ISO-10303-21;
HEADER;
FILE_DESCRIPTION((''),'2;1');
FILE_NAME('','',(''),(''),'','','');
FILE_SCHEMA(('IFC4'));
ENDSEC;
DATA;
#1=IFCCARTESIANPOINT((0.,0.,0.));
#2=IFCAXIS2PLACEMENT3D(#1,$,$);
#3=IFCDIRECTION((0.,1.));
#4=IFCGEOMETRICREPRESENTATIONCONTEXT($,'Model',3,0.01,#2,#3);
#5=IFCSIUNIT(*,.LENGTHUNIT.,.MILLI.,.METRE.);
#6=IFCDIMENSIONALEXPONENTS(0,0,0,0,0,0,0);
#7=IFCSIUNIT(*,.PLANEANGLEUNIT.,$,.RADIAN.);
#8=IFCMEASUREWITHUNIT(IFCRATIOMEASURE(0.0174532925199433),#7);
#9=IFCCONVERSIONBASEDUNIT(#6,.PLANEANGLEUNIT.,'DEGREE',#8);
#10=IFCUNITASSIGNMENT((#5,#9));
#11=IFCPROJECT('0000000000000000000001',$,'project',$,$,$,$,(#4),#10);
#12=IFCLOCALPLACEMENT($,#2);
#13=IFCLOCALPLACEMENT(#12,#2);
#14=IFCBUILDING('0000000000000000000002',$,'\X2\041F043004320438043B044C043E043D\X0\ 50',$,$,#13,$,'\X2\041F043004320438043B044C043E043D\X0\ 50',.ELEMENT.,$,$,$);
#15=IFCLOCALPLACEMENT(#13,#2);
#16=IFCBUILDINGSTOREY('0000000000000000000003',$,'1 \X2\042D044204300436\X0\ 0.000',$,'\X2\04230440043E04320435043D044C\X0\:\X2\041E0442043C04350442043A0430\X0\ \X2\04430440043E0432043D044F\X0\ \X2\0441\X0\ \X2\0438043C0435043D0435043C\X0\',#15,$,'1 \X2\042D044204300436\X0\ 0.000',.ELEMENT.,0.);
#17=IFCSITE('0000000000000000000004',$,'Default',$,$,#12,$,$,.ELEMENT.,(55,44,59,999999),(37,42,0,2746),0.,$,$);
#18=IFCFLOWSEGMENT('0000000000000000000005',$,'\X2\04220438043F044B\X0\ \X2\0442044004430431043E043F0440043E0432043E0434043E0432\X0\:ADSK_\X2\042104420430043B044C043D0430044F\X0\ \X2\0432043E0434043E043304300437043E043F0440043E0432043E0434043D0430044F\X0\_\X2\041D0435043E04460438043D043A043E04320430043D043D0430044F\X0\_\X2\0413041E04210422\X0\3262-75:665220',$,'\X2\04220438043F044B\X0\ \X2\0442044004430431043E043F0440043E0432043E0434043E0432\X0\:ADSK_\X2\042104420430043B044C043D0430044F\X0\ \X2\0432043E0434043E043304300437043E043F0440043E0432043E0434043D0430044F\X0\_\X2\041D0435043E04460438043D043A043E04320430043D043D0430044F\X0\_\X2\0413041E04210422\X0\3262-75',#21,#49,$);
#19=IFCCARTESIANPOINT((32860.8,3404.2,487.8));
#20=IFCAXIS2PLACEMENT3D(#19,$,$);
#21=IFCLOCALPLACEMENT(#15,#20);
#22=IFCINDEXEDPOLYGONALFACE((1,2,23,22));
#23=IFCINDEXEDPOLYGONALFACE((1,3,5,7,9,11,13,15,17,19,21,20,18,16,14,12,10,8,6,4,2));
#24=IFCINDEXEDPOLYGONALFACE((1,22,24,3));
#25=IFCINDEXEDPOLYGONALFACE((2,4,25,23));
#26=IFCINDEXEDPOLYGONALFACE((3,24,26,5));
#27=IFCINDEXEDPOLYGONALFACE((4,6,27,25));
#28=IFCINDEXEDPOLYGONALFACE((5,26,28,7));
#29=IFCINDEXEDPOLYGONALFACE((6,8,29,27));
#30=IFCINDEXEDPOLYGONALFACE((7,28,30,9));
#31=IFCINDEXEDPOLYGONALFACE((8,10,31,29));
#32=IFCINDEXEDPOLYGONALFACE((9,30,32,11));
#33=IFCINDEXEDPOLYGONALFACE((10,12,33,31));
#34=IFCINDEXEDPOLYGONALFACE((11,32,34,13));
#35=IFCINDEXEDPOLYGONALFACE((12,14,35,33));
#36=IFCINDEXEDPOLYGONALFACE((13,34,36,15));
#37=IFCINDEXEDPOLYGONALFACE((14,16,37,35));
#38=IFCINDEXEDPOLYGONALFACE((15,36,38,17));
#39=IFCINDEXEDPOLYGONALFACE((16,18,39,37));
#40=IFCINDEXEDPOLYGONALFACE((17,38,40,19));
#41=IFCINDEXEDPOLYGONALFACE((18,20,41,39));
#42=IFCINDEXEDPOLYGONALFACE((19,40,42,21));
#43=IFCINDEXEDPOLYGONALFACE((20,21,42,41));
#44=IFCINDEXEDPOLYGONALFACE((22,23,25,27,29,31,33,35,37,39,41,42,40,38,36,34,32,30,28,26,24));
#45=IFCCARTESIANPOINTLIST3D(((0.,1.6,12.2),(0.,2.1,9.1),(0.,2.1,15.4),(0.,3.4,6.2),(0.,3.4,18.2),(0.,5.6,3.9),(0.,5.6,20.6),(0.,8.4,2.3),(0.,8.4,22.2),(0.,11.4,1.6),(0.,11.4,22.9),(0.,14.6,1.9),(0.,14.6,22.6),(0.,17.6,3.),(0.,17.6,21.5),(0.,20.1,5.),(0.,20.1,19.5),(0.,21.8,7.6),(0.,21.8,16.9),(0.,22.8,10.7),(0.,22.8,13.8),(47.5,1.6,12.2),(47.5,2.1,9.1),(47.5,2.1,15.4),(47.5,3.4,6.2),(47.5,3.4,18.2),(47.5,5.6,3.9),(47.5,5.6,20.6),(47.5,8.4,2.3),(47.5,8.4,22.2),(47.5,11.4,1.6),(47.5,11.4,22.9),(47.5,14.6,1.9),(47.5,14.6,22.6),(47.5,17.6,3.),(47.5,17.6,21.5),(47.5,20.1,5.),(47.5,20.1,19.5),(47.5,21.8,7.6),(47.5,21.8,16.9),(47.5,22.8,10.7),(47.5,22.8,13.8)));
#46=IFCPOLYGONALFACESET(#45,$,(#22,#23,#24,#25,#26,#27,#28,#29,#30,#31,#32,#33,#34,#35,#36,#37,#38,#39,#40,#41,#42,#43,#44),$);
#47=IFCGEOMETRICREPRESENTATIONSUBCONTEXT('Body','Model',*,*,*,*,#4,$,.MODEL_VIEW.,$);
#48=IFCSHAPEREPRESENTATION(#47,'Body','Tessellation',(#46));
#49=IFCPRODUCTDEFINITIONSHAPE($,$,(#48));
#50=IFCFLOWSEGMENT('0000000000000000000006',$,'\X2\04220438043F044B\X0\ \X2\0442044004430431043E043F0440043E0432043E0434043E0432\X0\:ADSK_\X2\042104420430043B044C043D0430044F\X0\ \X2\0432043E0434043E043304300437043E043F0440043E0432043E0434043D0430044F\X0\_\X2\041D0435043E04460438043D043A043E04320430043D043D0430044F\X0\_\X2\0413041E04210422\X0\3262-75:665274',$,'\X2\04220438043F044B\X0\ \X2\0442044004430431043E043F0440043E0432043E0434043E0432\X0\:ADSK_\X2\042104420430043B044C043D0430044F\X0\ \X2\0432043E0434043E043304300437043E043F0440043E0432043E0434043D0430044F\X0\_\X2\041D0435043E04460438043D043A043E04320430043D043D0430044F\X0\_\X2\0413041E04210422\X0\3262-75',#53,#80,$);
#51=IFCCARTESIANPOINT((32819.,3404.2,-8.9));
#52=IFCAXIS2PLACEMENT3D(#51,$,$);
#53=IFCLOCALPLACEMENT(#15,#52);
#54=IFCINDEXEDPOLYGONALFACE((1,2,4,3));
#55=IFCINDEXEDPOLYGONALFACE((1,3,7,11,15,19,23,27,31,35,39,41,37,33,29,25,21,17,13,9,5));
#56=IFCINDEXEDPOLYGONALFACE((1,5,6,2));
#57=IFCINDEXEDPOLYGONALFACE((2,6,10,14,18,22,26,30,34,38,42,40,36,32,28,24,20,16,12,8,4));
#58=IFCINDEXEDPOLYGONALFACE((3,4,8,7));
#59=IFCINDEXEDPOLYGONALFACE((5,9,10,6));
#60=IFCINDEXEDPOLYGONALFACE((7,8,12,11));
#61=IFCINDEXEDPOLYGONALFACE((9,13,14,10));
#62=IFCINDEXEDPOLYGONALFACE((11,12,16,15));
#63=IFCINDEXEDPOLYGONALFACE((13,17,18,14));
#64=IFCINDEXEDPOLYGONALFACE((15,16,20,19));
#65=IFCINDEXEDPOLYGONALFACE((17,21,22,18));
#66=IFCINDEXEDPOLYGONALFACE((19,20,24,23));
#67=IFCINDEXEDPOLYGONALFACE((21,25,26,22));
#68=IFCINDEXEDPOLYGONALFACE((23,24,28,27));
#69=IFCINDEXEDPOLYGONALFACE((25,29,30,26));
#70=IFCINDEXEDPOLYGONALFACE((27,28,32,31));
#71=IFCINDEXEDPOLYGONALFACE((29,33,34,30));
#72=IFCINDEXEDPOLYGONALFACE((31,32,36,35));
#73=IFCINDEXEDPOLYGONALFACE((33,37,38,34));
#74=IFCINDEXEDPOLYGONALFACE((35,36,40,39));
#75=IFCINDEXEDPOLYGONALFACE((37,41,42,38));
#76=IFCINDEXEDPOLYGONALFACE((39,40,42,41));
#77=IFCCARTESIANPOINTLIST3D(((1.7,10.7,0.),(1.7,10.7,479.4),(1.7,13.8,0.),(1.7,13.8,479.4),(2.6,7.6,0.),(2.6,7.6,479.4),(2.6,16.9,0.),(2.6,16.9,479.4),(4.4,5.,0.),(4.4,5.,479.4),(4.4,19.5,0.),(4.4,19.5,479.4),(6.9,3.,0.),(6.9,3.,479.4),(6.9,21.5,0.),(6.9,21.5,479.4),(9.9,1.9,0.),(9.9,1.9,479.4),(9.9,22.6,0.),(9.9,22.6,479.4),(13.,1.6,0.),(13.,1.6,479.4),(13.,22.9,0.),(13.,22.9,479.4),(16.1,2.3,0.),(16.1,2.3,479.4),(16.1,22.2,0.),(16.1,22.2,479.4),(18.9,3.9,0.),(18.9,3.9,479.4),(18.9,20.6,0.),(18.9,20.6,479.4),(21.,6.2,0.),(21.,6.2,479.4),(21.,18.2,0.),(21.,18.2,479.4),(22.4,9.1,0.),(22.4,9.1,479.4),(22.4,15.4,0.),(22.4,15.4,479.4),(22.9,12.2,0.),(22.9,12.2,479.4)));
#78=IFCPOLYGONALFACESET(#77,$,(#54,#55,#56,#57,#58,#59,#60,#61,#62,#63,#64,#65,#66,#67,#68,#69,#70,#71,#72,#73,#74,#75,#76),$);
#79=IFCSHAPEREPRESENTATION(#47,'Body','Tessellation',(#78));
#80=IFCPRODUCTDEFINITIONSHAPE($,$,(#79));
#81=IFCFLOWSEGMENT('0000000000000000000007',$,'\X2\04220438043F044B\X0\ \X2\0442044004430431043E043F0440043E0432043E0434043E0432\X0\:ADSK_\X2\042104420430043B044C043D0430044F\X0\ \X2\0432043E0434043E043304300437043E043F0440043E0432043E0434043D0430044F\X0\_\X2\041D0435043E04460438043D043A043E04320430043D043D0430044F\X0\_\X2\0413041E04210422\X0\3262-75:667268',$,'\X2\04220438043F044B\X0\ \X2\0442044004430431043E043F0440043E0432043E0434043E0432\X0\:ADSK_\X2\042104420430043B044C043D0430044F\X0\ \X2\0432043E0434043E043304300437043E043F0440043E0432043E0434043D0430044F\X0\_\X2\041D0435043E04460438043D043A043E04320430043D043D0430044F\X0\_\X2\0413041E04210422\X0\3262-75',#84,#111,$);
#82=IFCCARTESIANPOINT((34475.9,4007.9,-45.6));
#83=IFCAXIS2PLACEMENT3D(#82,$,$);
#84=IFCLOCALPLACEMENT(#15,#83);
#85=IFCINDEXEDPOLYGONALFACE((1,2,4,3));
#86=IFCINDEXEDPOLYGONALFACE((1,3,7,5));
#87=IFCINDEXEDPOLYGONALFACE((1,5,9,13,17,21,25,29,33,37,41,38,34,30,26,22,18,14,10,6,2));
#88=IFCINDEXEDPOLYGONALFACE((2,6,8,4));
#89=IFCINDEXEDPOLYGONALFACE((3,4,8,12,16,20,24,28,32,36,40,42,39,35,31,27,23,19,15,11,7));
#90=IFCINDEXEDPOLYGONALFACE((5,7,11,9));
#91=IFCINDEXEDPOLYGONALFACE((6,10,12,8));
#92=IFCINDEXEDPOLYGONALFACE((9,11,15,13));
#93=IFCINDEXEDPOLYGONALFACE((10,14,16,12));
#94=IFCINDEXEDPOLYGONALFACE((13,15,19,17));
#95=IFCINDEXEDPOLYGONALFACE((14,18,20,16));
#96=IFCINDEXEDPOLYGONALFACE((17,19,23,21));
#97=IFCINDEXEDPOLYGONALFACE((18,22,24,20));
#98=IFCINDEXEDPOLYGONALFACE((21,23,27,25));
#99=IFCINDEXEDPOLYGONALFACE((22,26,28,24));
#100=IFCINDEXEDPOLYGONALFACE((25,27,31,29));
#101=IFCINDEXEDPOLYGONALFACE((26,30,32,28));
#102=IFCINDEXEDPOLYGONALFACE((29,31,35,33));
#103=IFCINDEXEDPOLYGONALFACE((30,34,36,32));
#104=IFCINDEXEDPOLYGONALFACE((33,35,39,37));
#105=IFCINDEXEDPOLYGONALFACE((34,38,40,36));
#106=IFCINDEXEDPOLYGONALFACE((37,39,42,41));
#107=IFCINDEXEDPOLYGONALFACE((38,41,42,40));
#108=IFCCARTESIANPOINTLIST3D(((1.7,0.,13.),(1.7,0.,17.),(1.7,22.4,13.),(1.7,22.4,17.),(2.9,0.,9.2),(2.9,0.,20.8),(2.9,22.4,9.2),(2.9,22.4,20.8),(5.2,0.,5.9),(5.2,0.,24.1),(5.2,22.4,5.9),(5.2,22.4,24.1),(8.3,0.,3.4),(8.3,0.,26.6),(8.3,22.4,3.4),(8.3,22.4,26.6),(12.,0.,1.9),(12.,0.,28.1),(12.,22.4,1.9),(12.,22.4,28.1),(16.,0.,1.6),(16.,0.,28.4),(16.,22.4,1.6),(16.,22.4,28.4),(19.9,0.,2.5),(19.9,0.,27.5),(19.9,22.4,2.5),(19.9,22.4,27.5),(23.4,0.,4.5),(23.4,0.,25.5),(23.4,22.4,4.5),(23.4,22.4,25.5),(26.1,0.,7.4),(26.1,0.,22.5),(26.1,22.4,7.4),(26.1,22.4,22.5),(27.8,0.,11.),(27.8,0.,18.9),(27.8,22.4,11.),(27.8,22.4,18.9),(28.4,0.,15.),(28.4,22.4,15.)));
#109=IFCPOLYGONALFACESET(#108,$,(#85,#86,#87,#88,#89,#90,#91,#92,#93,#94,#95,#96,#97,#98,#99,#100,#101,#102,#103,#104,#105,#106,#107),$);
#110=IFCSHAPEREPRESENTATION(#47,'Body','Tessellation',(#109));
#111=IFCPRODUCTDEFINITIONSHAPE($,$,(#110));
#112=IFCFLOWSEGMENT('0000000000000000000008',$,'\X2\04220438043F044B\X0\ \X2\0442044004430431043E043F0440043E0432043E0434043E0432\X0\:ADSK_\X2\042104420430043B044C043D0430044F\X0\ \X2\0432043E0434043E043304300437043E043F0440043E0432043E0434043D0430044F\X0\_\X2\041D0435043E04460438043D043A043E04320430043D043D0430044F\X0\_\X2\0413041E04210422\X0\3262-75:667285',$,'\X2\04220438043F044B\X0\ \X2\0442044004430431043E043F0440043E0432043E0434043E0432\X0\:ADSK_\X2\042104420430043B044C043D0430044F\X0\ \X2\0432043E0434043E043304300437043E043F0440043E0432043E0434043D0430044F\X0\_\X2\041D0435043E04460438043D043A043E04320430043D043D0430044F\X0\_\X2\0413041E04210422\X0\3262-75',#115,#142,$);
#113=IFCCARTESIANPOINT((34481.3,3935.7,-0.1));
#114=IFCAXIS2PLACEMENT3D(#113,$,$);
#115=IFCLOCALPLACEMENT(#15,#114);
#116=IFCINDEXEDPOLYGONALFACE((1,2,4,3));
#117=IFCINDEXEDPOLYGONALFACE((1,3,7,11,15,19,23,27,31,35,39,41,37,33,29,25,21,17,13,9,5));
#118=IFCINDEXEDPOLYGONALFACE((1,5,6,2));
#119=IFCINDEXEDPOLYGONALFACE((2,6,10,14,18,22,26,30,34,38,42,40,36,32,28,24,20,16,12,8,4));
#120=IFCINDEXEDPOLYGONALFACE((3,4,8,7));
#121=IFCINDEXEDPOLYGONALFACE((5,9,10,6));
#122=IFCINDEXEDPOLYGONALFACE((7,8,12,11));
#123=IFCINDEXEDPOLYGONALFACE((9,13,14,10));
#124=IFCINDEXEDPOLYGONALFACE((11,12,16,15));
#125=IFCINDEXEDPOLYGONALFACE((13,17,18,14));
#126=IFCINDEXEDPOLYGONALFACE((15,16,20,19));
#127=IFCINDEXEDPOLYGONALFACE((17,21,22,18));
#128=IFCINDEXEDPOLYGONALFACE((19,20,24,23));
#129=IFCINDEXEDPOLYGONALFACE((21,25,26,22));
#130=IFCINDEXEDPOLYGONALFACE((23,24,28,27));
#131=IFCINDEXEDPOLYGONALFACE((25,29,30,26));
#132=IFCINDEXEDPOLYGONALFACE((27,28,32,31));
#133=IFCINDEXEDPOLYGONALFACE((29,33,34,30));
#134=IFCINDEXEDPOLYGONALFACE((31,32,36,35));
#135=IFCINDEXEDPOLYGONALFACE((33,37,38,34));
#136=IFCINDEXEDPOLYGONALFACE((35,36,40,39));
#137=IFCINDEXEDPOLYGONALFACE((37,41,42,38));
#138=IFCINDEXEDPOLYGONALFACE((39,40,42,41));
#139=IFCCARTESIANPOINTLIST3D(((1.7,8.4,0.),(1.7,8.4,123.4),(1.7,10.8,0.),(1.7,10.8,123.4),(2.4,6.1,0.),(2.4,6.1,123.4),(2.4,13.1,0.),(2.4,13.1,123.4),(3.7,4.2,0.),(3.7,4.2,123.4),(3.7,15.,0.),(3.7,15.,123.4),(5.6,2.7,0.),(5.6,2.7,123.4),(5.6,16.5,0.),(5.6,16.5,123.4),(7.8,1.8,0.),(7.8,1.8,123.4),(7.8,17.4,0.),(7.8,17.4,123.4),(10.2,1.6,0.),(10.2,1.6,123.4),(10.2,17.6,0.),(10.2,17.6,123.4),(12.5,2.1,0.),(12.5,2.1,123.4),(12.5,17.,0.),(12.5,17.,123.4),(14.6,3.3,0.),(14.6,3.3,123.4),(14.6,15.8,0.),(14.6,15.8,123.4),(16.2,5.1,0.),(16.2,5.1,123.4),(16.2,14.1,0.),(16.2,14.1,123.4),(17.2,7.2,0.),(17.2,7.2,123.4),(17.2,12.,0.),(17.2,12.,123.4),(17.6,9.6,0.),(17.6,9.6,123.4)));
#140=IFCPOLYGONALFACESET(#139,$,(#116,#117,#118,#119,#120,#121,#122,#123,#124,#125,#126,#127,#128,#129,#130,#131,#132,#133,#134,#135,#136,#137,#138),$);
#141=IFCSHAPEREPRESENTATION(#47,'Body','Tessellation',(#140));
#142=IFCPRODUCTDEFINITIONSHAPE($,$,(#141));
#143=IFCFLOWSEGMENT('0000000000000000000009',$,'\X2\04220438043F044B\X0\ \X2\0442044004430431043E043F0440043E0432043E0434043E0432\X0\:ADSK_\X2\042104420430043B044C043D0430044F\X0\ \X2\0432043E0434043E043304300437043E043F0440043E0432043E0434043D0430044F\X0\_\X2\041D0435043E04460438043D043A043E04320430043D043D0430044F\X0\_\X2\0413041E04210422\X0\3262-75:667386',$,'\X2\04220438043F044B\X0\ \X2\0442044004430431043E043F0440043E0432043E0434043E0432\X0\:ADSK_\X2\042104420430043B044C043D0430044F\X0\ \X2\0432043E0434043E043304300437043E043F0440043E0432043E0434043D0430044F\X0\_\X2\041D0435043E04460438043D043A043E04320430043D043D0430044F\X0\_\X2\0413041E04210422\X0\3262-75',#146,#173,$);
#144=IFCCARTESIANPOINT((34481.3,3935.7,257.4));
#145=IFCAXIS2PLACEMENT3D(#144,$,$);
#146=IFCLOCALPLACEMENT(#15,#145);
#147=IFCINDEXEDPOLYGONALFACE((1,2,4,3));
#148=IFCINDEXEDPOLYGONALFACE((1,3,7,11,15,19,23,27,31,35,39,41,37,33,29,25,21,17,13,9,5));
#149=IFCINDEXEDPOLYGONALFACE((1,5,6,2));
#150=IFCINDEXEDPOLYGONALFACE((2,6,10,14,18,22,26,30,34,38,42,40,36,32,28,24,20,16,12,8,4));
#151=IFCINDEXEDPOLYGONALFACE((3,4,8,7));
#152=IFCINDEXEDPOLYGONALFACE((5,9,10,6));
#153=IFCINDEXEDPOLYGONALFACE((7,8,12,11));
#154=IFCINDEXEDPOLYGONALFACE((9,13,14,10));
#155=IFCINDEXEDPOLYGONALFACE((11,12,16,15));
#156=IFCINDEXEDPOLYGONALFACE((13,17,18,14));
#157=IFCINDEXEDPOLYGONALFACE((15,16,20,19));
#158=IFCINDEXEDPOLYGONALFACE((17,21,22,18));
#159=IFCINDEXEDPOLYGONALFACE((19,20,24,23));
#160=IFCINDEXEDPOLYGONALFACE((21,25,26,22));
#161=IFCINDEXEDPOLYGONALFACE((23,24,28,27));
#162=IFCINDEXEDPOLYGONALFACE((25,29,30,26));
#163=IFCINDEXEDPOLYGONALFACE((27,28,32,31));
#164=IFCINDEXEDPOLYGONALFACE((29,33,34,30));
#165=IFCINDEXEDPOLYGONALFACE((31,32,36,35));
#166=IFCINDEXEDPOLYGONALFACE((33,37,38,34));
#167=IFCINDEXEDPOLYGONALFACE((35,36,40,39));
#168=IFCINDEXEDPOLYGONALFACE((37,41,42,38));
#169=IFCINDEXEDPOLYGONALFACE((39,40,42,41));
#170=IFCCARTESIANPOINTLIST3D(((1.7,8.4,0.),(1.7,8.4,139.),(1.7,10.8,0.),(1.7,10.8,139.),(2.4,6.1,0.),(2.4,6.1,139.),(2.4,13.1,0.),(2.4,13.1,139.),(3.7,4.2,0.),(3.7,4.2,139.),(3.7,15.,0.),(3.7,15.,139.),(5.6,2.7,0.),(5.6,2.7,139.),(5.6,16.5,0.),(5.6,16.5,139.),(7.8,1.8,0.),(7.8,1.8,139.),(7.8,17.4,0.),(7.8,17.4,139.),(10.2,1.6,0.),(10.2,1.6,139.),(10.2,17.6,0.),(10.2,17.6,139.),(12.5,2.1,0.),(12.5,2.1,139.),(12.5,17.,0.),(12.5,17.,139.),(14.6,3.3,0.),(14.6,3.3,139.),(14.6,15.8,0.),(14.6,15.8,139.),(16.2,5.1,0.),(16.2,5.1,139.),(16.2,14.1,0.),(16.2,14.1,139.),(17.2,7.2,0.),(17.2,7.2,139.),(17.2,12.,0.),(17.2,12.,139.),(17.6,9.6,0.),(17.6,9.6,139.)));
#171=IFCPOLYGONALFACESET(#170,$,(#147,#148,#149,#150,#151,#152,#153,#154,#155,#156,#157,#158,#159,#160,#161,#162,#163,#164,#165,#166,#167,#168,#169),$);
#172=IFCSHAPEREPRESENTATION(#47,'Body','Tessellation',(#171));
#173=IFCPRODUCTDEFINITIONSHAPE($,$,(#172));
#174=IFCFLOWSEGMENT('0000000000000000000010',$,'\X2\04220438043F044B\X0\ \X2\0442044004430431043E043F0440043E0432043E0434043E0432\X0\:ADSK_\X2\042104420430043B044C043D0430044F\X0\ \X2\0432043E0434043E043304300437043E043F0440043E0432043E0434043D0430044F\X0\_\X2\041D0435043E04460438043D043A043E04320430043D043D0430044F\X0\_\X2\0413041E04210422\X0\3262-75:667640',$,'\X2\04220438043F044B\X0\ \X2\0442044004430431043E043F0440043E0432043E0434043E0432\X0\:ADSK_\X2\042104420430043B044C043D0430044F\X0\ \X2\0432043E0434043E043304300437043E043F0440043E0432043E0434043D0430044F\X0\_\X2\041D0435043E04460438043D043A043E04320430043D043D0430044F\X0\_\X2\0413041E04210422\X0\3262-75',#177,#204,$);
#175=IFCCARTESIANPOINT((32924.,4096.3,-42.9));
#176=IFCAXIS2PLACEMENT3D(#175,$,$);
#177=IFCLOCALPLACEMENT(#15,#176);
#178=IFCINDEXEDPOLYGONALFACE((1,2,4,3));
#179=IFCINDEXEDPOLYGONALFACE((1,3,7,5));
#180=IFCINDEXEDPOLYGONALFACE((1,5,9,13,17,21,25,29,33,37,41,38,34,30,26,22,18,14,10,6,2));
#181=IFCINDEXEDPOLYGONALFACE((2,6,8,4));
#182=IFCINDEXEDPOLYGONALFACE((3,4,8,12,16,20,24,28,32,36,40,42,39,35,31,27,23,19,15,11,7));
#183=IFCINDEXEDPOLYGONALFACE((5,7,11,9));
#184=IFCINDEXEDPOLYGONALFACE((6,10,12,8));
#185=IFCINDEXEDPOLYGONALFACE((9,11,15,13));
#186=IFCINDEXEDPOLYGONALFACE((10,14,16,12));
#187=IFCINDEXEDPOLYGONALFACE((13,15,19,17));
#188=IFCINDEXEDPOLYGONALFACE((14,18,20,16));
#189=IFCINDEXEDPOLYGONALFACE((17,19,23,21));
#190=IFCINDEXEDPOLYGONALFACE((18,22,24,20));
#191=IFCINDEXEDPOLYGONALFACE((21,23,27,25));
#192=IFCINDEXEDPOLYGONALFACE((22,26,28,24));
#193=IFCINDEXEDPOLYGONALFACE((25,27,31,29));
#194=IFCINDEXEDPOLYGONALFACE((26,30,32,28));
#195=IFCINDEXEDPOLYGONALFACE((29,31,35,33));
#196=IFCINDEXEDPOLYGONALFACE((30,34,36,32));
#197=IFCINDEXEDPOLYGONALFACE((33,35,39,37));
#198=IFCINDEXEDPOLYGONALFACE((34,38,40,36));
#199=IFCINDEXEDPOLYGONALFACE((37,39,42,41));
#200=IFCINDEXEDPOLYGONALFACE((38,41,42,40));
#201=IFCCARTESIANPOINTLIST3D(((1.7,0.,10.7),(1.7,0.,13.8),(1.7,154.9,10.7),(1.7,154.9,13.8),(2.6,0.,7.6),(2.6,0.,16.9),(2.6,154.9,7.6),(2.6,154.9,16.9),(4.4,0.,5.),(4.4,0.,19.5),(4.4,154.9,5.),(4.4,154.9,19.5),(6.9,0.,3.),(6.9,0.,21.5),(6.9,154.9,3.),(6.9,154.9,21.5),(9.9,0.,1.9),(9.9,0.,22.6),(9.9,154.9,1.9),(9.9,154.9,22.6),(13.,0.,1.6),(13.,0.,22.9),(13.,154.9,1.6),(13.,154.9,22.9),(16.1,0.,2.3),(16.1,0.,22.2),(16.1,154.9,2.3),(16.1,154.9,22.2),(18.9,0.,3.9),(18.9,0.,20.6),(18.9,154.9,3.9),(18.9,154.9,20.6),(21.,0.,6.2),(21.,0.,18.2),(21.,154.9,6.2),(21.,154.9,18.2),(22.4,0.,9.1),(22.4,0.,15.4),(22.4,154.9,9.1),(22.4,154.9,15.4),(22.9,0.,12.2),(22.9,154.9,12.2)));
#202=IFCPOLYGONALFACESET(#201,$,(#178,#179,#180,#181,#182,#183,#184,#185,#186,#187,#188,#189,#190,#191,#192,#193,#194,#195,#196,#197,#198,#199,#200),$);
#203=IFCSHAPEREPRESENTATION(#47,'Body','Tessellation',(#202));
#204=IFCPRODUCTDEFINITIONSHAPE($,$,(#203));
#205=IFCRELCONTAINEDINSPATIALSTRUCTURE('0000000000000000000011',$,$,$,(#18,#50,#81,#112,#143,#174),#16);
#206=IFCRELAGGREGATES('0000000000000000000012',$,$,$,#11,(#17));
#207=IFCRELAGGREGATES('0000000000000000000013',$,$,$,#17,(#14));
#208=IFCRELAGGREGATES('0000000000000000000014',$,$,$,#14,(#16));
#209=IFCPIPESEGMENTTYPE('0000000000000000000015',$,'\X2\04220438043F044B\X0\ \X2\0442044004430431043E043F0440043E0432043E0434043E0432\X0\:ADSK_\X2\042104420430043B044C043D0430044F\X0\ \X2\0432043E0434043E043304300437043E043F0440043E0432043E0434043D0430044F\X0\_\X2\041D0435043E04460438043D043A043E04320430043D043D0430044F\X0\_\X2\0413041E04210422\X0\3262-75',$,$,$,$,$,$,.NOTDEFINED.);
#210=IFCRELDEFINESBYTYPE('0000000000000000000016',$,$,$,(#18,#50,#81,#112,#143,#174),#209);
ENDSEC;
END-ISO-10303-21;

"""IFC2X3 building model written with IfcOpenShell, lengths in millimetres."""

from ifc_helpers import new_model, entity, si_unit, converted_unit, direction, frame, frame_2d, origin, origin_2d_with_axis, place, context, subcontext, project, spatial, circle, extrude, type_object, element, save


model = new_model("IFC2X3")

# Units and contexts
model_context = context("Model", 3, precision=0.01, world=origin(), true_north=direction((0.0, 1.0)))
body_context = subcontext(model_context, "Body", "Model", "MODEL_VIEW")
ifc_project = project(units=[si_unit("LENGTHUNIT", "METRE", prefix="MILLI"), converted_unit("PLANEANGLEUNIT", "DEGREE", entity("IfcRatioMeasure", 0.0174532925199433), si_unit("PLANEANGLEUNIT", "RADIAN"), dimensions=[0, 0, 0, 0, 0, 0, 0])], contexts=[model_context])

# Site, building, storey
site_placement = place(None, origin())
site = spatial("IfcSite", under=ifc_project, at=site_placement, Name="Default", CompositionType="ELEMENT", RefLatitude=(55, 44, 59, 999999), RefLongitude=(37, 42, 0, 2746), RefElevation=0.0)
building_placement = place(site_placement, origin())
building = spatial("IfcBuilding", under=site, at=building_placement, Name="Павильон 50", LongName="Павильон 50", CompositionType="ELEMENT")
storey_placement = place(building_placement, origin())
storey = spatial("IfcBuildingStorey", under=building, at=storey_placement, Name="1 Этаж 0.000", ObjectType="Уровень:Отметка уровня с именем", LongName="1 Этаж 0.000", CompositionType="ELEMENT", Elevation=0.0)

# Flow segments
pipe_segment_type = type_object("IfcPipeSegmentType", Name="Типы трубопроводов:ADSK_Стальная водогазопроводная_Неоцинкованная_ГОСТ3262-75", PredefinedType="NOTDEFINED")
flow_segment_1_placement = place(storey_placement, frame((32860.8, 3404.2, 487.8)))
element("IfcFlowSegment", 1, at=flow_segment_1_placement, inside=storey, type_object=pipe_segment_type, Name="Типы трубопроводов:ADSK_Стальная водогазопроводная_Неоцинкованная_ГОСТ3262-75:665220", ObjectType="Типы трубопроводов:ADSK_Стальная водогазопроводная_Неоцинкованная_ГОСТ3262-75", context=body_context, shape_type="SweptSolid", body=[
    extrude(circle(Radius=10.7, at=frame_2d((0.0, 0.0), x_axis=(1.0, 0.0))), frame((0.0, 12.2, 12.2), z_axis=(1.0, 0.0, 0.0), x_axis=(0.0, -1.0, 0.0)), (0.0, 0.0, 1.0), 47.5),
])
flow_segment_2_placement = place(storey_placement, frame((32819.0, 3404.2, -8.9)))
element("IfcFlowSegment", 2, at=flow_segment_2_placement, inside=storey, type_object=pipe_segment_type, Name="Типы трубопроводов:ADSK_Стальная водогазопроводная_Неоцинкованная_ГОСТ3262-75:665274", ObjectType="Типы трубопроводов:ADSK_Стальная водогазопроводная_Неоцинкованная_ГОСТ3262-75", context=body_context, shape_type="SweptSolid", body=[
    extrude(circle(Radius=10.7, at=origin_2d_with_axis()), frame((12.2, 12.2, 0.0)), (0.0, 0.0, 1.0), 479.4),
])
flow_segment_3_placement = place(storey_placement, frame((34475.9, 4007.9, -45.6)))
element("IfcFlowSegment", 3, at=flow_segment_3_placement, inside=storey, type_object=pipe_segment_type, Name="Типы трубопроводов:ADSK_Стальная водогазопроводная_Неоцинкованная_ГОСТ3262-75:667268", ObjectType="Типы трубопроводов:ADSK_Стальная водогазопроводная_Неоцинкованная_ГОСТ3262-75", context=body_context, shape_type="SweptSolid", body=[
    extrude(circle(Radius=13.4, at=frame_2d((0.0, 0.0), x_axis=(1.0, 0.0))), frame((15.0, 0.0, 15.0), z_axis=(0.0, 1.0, 0.0), x_axis=(1.0, 0.0, 0.0)), (0.0, 0.0, 1.0), 22.4),
])
flow_segment_4_placement = place(storey_placement, frame((34481.3, 3935.7, -0.1)))
element("IfcFlowSegment", 4, at=flow_segment_4_placement, inside=storey, type_object=pipe_segment_type, Name="Типы трубопроводов:ADSK_Стальная водогазопроводная_Неоцинкованная_ГОСТ3262-75:667285", ObjectType="Типы трубопроводов:ADSK_Стальная водогазопроводная_Неоцинкованная_ГОСТ3262-75", context=body_context, shape_type="SweptSolid", body=[
    extrude(circle(Radius=8.0, at=origin_2d_with_axis()), frame((9.6, 9.6, 0.0)), (0.0, 0.0, 1.0), 123.4),
])
flow_segment_5_placement = place(storey_placement, frame((34481.3, 3935.7, 257.4)))
element("IfcFlowSegment", 5, at=flow_segment_5_placement, inside=storey, type_object=pipe_segment_type, Name="Типы трубопроводов:ADSK_Стальная водогазопроводная_Неоцинкованная_ГОСТ3262-75:667386", ObjectType="Типы трубопроводов:ADSK_Стальная водогазопроводная_Неоцинкованная_ГОСТ3262-75", context=body_context, shape_type="SweptSolid", body=[
    extrude(circle(Radius=8.0, at=frame_2d((0.0, 0.0), x_axis=(1.0, 0.0))), frame((9.6, 9.6, 0.0)), (0.0, 0.0, 1.0), 139.0),
])
flow_segment_6_placement = place(storey_placement, frame((32924.0, 4096.3, -42.9)))
element("IfcFlowSegment", 6, at=flow_segment_6_placement, inside=storey, type_object=pipe_segment_type, Name="Типы трубопроводов:ADSK_Стальная водогазопроводная_Неоцинкованная_ГОСТ3262-75:667640", ObjectType="Типы трубопроводов:ADSK_Стальная водогазопроводная_Неоцинкованная_ГОСТ3262-75", context=body_context, shape_type="SweptSolid", body=[
    extrude(circle(Radius=10.7, at=frame_2d((0.0, 0.0), x_axis=(1.0, 0.0))), frame((12.2, 0.0, 12.2), z_axis=(0.0, 1.0, 0.0), x_axis=(1.0, 0.0, 0.0)), (0.0, 0.0, 1.0), 154.9),
])

save(model, "model.ifc")
